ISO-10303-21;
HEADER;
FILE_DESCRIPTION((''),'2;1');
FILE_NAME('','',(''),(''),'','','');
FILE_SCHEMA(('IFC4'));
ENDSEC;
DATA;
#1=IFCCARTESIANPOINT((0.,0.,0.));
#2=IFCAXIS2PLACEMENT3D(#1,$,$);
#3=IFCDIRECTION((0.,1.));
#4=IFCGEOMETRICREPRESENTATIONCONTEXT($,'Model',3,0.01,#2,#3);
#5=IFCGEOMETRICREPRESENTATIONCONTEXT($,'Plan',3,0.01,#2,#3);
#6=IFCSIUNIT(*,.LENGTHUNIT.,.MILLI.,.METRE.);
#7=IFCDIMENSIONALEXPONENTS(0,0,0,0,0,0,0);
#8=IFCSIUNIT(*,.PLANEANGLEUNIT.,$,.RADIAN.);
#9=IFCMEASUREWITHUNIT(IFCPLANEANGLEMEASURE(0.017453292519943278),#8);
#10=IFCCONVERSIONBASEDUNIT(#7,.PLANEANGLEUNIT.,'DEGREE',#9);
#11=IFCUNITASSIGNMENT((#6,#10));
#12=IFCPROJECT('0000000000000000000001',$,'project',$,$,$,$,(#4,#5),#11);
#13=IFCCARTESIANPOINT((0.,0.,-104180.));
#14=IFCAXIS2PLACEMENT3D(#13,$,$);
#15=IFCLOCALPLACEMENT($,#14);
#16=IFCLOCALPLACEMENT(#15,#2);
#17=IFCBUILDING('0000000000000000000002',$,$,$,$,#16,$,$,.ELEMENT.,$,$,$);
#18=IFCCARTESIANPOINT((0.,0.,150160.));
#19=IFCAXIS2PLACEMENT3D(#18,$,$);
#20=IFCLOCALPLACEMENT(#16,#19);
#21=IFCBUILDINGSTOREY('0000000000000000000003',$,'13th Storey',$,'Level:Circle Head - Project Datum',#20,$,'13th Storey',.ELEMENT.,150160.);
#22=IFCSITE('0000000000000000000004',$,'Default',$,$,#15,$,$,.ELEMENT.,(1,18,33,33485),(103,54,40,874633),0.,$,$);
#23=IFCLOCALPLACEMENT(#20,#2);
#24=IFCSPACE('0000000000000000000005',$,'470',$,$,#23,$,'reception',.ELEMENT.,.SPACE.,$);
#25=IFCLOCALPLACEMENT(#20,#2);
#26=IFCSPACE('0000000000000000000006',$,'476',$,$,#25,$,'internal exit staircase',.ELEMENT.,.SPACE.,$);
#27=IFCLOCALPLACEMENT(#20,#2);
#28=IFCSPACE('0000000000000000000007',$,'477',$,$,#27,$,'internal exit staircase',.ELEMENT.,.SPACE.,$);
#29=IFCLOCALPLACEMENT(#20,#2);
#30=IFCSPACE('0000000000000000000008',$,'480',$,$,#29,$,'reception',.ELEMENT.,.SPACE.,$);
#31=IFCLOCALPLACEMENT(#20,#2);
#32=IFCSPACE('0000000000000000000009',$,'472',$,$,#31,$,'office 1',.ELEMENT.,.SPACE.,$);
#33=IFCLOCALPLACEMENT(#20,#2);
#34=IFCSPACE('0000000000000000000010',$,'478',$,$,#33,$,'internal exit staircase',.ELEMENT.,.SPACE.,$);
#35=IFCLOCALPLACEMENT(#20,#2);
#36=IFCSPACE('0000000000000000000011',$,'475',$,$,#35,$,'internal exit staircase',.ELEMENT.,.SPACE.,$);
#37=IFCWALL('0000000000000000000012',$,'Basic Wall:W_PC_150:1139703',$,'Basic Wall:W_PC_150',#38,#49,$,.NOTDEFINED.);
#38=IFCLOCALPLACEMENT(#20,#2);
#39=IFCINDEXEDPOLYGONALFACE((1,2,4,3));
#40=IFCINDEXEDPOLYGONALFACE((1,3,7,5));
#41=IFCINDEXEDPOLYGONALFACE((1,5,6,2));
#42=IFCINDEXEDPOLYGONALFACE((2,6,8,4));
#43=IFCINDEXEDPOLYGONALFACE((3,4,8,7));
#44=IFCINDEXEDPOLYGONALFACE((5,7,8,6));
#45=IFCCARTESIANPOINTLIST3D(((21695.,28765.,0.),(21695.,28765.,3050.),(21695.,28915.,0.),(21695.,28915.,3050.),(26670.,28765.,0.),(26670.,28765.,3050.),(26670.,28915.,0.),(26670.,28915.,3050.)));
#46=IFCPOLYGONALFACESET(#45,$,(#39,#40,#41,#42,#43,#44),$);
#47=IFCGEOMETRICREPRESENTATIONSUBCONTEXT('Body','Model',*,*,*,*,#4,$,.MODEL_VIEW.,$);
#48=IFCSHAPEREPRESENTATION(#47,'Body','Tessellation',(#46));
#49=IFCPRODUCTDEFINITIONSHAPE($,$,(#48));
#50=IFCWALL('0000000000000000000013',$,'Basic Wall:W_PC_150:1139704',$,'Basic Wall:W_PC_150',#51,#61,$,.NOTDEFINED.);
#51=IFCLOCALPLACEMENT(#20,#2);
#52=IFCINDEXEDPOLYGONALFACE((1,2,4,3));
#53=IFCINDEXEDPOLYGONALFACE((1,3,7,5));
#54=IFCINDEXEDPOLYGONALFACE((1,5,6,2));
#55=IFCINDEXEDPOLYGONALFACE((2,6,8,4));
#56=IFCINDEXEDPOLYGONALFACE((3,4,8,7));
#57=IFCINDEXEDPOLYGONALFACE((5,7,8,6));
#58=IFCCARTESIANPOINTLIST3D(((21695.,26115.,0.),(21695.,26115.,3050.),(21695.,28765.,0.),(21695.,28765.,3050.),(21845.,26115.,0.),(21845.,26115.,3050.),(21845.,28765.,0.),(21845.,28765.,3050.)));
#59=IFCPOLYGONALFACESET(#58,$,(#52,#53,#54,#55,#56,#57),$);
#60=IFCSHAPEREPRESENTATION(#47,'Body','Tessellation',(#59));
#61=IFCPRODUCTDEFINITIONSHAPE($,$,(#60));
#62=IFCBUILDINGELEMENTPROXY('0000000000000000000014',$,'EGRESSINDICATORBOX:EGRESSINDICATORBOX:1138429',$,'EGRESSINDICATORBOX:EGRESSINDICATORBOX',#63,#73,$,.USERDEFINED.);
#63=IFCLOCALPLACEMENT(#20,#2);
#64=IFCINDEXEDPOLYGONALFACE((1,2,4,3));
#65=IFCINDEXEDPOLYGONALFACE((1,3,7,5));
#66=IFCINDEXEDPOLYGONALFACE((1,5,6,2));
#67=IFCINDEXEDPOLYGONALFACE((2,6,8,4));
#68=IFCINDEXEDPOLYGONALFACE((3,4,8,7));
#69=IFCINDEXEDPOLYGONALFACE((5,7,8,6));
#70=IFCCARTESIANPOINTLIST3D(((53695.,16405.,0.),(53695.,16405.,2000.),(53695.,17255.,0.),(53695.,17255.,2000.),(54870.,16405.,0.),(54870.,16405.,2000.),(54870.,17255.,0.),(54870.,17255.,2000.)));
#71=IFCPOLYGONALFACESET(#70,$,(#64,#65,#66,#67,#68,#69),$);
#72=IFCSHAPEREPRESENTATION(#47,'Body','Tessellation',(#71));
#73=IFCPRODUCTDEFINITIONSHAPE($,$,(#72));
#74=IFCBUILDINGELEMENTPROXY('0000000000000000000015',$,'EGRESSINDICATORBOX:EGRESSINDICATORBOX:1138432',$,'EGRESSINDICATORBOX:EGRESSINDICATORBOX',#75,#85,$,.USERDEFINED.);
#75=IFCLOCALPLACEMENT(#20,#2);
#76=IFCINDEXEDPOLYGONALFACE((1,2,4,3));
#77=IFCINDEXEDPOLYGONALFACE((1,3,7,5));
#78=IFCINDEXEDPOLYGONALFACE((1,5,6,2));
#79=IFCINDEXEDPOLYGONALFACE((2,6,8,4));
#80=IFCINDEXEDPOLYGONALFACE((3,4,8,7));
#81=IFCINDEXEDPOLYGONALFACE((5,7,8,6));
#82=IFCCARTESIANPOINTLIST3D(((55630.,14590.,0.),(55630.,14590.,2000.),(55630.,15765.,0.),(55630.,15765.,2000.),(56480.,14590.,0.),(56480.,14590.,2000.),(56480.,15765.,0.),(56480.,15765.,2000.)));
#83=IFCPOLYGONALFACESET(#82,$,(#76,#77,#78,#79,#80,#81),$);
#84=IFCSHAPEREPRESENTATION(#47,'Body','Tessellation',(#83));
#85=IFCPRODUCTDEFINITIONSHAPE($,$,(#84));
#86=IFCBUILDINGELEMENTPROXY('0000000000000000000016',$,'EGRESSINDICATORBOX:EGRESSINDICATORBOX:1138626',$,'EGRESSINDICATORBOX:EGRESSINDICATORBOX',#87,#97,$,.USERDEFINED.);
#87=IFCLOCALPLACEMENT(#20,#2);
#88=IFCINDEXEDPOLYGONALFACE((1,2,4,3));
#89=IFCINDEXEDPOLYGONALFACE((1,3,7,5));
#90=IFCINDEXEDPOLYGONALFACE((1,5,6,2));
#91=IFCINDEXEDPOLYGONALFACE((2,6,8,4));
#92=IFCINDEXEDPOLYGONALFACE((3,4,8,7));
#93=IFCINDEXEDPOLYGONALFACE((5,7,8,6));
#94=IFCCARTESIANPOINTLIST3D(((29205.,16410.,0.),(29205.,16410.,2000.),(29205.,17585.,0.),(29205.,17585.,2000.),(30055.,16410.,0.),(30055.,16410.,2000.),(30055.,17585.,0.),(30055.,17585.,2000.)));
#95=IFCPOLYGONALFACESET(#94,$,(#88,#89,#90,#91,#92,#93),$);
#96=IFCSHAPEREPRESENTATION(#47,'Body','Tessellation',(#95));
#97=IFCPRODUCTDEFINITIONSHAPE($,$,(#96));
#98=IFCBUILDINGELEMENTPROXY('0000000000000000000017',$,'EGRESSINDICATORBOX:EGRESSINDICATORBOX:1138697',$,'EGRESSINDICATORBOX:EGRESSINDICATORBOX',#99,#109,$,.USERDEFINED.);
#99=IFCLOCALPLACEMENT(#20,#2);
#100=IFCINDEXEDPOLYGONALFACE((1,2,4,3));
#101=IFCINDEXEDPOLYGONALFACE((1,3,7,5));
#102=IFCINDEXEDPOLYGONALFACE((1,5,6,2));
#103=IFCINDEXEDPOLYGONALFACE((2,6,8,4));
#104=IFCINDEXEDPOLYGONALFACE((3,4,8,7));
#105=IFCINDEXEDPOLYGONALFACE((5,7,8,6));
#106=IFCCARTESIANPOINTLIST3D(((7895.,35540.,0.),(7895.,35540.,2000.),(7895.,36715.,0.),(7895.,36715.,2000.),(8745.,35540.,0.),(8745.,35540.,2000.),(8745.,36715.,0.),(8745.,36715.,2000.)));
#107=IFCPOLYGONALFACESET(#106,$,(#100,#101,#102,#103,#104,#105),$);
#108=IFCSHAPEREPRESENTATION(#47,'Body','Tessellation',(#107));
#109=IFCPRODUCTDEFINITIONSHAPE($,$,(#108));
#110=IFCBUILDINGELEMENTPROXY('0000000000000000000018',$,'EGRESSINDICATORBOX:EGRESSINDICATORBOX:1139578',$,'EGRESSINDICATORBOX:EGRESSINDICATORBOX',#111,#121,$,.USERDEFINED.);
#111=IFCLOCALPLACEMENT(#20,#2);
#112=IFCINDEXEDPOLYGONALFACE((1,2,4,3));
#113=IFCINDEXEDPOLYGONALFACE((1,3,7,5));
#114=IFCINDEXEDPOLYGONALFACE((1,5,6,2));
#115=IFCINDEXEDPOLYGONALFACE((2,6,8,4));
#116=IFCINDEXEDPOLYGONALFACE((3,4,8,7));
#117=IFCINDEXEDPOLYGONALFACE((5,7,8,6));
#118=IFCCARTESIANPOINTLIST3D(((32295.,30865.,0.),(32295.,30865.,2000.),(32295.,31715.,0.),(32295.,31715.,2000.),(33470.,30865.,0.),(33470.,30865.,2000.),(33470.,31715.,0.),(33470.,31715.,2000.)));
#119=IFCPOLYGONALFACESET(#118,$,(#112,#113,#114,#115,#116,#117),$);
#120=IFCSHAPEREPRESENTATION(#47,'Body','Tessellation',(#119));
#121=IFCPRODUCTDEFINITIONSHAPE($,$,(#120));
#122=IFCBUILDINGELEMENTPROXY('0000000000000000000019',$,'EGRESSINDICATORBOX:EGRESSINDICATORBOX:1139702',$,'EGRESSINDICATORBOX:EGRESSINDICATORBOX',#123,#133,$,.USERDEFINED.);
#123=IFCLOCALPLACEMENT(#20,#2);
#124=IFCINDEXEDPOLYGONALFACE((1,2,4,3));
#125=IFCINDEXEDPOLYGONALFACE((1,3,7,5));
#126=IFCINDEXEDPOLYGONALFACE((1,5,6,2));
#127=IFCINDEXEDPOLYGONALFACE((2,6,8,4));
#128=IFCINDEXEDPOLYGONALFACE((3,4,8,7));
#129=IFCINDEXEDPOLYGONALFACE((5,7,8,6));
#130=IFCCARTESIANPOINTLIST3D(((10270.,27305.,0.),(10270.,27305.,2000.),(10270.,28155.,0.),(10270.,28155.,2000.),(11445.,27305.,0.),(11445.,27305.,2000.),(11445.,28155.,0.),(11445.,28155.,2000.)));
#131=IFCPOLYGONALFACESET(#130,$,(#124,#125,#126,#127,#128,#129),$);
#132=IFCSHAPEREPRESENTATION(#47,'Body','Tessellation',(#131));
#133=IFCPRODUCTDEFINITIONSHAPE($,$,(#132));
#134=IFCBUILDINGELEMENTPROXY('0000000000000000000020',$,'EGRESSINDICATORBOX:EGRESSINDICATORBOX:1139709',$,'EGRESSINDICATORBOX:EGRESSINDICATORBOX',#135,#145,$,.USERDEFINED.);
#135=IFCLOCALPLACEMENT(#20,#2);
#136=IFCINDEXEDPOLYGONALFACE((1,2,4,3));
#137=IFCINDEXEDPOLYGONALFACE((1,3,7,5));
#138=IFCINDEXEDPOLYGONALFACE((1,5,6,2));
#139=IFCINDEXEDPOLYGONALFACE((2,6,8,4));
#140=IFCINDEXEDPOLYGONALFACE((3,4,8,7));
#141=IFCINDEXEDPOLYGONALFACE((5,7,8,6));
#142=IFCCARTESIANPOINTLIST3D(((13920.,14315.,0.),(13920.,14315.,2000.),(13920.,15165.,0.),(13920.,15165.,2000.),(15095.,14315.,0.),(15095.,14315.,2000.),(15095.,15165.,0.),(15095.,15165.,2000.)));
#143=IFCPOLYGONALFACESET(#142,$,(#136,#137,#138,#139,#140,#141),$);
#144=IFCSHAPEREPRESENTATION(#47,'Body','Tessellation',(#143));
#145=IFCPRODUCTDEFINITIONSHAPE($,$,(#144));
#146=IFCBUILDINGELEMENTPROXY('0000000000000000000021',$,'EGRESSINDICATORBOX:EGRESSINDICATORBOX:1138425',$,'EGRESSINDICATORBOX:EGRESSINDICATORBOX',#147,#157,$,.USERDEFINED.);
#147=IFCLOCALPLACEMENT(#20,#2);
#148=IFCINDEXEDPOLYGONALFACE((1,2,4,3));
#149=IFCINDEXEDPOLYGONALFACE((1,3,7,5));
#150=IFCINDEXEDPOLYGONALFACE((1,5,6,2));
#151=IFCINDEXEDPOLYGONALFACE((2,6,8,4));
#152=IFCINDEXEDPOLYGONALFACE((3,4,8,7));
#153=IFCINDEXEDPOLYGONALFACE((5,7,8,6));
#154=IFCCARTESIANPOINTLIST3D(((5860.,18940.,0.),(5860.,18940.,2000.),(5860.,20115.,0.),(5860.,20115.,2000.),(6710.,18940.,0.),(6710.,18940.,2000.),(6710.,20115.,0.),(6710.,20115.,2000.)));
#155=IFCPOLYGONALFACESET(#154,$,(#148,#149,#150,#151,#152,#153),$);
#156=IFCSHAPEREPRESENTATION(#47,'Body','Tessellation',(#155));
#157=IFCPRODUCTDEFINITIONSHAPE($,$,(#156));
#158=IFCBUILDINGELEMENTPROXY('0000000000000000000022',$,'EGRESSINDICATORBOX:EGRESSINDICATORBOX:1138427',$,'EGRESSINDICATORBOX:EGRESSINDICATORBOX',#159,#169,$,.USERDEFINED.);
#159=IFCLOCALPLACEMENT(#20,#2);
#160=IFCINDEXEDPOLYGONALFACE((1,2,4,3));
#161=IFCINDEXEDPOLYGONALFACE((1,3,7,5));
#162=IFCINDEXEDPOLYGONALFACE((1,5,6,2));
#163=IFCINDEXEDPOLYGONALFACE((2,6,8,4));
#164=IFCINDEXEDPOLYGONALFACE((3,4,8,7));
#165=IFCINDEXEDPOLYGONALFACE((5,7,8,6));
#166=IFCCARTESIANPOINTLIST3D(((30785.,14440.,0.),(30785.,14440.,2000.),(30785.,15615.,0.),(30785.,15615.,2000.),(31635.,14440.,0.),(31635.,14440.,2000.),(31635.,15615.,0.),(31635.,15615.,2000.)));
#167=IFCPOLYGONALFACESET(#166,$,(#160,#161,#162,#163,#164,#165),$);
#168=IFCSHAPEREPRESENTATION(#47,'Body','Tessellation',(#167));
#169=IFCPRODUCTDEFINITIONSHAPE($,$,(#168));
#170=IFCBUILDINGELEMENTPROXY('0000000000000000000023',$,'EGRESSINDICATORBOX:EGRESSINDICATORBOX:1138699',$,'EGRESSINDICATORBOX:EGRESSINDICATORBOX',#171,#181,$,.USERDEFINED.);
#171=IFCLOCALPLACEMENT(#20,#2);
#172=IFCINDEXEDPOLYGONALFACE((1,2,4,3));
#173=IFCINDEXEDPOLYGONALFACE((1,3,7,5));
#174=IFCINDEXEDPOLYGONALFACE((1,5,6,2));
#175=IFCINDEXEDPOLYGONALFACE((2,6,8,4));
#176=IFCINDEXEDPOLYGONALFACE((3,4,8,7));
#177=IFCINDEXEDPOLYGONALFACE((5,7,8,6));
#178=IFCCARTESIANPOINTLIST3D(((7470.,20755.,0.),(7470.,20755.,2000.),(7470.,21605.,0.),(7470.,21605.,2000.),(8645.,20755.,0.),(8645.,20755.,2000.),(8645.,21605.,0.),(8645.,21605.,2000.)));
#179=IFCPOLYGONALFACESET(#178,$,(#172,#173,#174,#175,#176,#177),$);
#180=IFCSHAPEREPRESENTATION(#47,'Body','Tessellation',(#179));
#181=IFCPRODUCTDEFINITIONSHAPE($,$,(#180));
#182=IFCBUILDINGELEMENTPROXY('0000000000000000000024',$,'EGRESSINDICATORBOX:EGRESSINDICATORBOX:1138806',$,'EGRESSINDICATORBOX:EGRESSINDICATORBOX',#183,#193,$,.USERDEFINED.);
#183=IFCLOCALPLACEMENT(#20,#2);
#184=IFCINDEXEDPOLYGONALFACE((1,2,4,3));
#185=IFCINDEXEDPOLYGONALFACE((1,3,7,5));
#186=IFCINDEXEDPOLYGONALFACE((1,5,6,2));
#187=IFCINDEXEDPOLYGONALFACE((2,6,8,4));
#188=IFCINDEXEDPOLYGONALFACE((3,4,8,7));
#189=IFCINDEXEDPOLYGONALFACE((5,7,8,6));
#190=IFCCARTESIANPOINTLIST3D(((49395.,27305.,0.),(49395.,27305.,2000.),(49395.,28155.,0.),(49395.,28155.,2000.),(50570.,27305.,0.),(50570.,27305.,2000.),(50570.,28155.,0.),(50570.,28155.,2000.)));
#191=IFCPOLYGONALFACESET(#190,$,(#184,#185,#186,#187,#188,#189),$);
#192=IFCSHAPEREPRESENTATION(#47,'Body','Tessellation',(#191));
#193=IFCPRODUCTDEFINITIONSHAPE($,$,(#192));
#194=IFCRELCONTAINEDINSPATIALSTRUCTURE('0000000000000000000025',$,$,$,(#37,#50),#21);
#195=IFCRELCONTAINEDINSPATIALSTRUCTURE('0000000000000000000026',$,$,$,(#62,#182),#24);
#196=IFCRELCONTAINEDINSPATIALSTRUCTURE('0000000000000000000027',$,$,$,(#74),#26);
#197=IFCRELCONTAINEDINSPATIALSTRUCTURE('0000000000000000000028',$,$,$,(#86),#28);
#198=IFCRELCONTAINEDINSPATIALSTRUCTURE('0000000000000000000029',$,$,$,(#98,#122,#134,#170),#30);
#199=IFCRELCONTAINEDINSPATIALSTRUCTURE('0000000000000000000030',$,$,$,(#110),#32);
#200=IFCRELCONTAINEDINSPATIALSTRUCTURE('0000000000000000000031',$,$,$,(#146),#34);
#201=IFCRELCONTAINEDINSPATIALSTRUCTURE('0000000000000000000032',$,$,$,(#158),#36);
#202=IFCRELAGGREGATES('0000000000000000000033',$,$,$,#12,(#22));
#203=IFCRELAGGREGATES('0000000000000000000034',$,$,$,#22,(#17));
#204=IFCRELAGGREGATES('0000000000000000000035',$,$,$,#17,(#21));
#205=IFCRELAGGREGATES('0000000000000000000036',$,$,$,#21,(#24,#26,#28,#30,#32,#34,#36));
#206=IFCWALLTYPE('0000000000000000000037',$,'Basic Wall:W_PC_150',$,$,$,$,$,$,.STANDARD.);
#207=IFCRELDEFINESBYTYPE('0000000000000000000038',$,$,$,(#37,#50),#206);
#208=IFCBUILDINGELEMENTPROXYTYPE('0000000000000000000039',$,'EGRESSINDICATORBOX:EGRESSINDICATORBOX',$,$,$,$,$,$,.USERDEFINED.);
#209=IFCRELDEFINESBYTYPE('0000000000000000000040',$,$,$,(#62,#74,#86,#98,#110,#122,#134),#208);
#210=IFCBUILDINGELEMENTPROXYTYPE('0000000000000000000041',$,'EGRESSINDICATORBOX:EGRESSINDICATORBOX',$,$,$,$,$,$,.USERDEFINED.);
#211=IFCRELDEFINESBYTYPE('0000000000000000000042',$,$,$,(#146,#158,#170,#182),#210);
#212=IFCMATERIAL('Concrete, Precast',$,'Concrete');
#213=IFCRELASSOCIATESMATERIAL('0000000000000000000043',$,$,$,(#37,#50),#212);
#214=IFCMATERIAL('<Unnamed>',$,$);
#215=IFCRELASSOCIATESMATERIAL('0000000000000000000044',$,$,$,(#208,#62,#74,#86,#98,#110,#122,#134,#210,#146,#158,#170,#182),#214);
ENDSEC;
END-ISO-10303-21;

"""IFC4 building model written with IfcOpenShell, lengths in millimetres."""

from ifc_helpers import new_model, entity, si_unit, converted_unit, direction, frame, origin, place, context, subcontext, project, spatial, indexed_curve, outline, extrude, source, transform, mapped, material, type_object, type_shapes, element, save


model = new_model("IFC4")

# Units and contexts
model_context = context("Model", 3, precision=0.01, world=origin(), true_north=direction((0.0, 1.0)))
plan_context = context("Plan", 3, precision=0.01, world=origin(), true_north=direction((0.0, 1.0)))
body_context = subcontext(model_context, "Body", "Model", "MODEL_VIEW")
ifc_project = project(units=[si_unit("LENGTHUNIT", "METRE", prefix="MILLI"), converted_unit("PLANEANGLEUNIT", "DEGREE", entity("IfcPlaneAngleMeasure", 0.017453292519943278), si_unit("PLANEANGLEUNIT", "RADIAN"), dimensions=[0, 0, 0, 0, 0, 0, 0])], contexts=[model_context, plan_context])

# Site, building, storey
site_placement = place(None, frame((0.0, 0.0, -104180.0)))
site = spatial("IfcSite", under=ifc_project, at=site_placement, Name="Default", CompositionType="ELEMENT", RefLatitude=(1, 18, 33, 33485), RefLongitude=(103, 54, 40, 874633), RefElevation=0.0)
building_placement = place(site_placement, origin())
building = spatial("IfcBuilding", under=site, at=building_placement, CompositionType="ELEMENT")
storey_placement = place(building_placement, frame((0.0, 0.0, 150160.0)))
storey = spatial("IfcBuildingStorey", under=building, at=storey_placement, Name="13th Storey", ObjectType="Level:Circle Head - Project Datum", LongName="13th Storey", CompositionType="ELEMENT", Elevation=150160.0)

# Shared definitions
ifc_material_1 = material(Name="Concrete, Precast", Category="Concrete")

# Walls
wall_type = type_object("IfcWallType", Name="Basic Wall:W_PC_150", PredefinedType="STANDARD")
wall_1_placement = place(storey_placement, frame((21695.0, 28840.0, 0.0)))
element("IfcWall", 1, at=wall_1_placement, inside=storey, type_object=wall_type, material=ifc_material_1, Name="Basic Wall:W_PC_150:1139703", ObjectType="Basic Wall:W_PC_150", PredefinedType="NOTDEFINED", context=body_context, shape_type="SweptSolid", body=[
    extrude(outline(indexed_curve([(4975.0, 75.0), (0.0, 75.0), (0.0, -75.0), (4975.0, -75.0), (4975.0, 75.0)], self_intersect=False)), origin(), (0.0, 0.0, 1.0), 3050.0),
])
wall_2_placement = place(storey_placement, frame((21770.0, 26115.0, 0.0), z_axis=(0.0, 0.0, 1.0), x_axis=(0.0, 1.0, 0.0)))
element("IfcWall", 2, at=wall_2_placement, inside=storey, type_object=wall_type, material=ifc_material_1, Name="Basic Wall:W_PC_150:1139704", ObjectType="Basic Wall:W_PC_150", PredefinedType="NOTDEFINED", context=body_context, shape_type="SweptSolid", body=[
    extrude(outline(indexed_curve([(2650.0, 75.0), (0.0, 75.0), (0.0, -75.0), (2650.0, -75.0), (2650.0, 75.0)], self_intersect=False)), origin(), (0.0, 0.0, 1.0), 3050.0),
])

# Shared definitions
space_1_placement = place(storey_placement, origin())
space_1 = spatial("IfcSpace", under=storey, at=space_1_placement, Name="470", LongName="reception", CompositionType="ELEMENT", PredefinedType="SPACE")

# Building element proxy
ifc_material_2 = material(Name="<Unnamed>")
building_element_proxy_type_1 = type_object("IfcBuildingElementProxyType", Name="EGRESSINDICATORBOX:EGRESSINDICATORBOX", PredefinedType="USERDEFINED", material=ifc_material_2)
shared_shape_1 = source(origin(), body_context, "Body", "SweptSolid", [
    extrude(outline(indexed_curve([(-587.5, -425.0), (587.5, -425.0), (587.5, 425.0), (-587.5, 425.0), (-587.5, -425.0)], self_intersect=False)), frame((0.0, 0.0, 0.0), z_axis=(0.0, 0.0, 1.0), x_axis=(0.0, 1.0, 0.0)), (0.0, 0.0, 1.0), 2000.0),
])
type_shapes(building_element_proxy_type_1, [shared_shape_1])
proxy_1_placement = place(space_1_placement, frame((54282.5, 16830.0, 0.0), z_axis=(0.0, 0.0, 1.0), x_axis=(0.0, -1.0, 0.0)))
element("IfcBuildingElementProxy", 3, at=proxy_1_placement, inside=space_1, type_object=building_element_proxy_type_1, material=ifc_material_2, Name="EGRESSINDICATORBOX:EGRESSINDICATORBOX:1138429", ObjectType="EGRESSINDICATORBOX:EGRESSINDICATORBOX", PredefinedType="USERDEFINED", context=body_context, shape_type="MappedRepresentation", body=[
    mapped(shared_shape_1, transform((0.0, 0.0, 0.0), scale=1.0)),
])

# Shared definitions
space_2_placement = place(storey_placement, origin())
space_2 = spatial("IfcSpace", under=storey, at=space_2_placement, Name="476", LongName="internal exit staircase", CompositionType="ELEMENT", PredefinedType="SPACE")

# Building element proxy
proxy_2_placement = place(space_2_placement, frame((56055.0, 15177.5, 0.0)))
element("IfcBuildingElementProxy", 4, at=proxy_2_placement, inside=space_2, type_object=building_element_proxy_type_1, material=ifc_material_2, Name="EGRESSINDICATORBOX:EGRESSINDICATORBOX:1138432", ObjectType="EGRESSINDICATORBOX:EGRESSINDICATORBOX", PredefinedType="USERDEFINED", context=body_context, shape_type="MappedRepresentation", body=[
    mapped(shared_shape_1, transform((0.0, 0.0, 0.0), scale=1.0)),
])

# Shared definitions
space_3_placement = place(storey_placement, origin())
space_3 = spatial("IfcSpace", under=storey, at=space_3_placement, Name="477", LongName="internal exit staircase", CompositionType="ELEMENT", PredefinedType="SPACE")

# Building element proxy
proxy_3_placement = place(space_3_placement, frame((29630.0, 16997.5, 0.0)))
element("IfcBuildingElementProxy", 5, at=proxy_3_placement, inside=space_3, type_object=building_element_proxy_type_1, material=ifc_material_2, Name="EGRESSINDICATORBOX:EGRESSINDICATORBOX:1138626", ObjectType="EGRESSINDICATORBOX:EGRESSINDICATORBOX", PredefinedType="USERDEFINED", context=body_context, shape_type="MappedRepresentation", body=[
    mapped(shared_shape_1, transform((0.0, 0.0, 0.0), scale=1.0)),
])

# Shared definitions
space_4_placement = place(storey_placement, origin())
space_4 = spatial("IfcSpace", under=storey, at=space_4_placement, Name="480", LongName="reception", CompositionType="ELEMENT", PredefinedType="SPACE")

# Building element proxy
proxy_4_placement = place(space_4_placement, frame((8320.0, 36127.5, 0.0)))
element("IfcBuildingElementProxy", 6, at=proxy_4_placement, inside=space_4, type_object=building_element_proxy_type_1, material=ifc_material_2, Name="EGRESSINDICATORBOX:EGRESSINDICATORBOX:1138697", ObjectType="EGRESSINDICATORBOX:EGRESSINDICATORBOX", PredefinedType="USERDEFINED", context=body_context, shape_type="MappedRepresentation", body=[
    mapped(shared_shape_1, transform((0.0, 0.0, 0.0), scale=1.0)),
])

# Shared definitions
space_5_placement = place(storey_placement, origin())
space_5 = spatial("IfcSpace", under=storey, at=space_5_placement, Name="472", LongName="office 1", CompositionType="ELEMENT", PredefinedType="SPACE")

# Building element proxies
proxy_5_placement = place(space_5_placement, frame((32882.5, 31290.0, 0.0), z_axis=(0.0, 0.0, 1.0), x_axis=(0.0, 1.0, 0.0)))
element("IfcBuildingElementProxy", 7, at=proxy_5_placement, inside=space_5, type_object=building_element_proxy_type_1, material=ifc_material_2, Name="EGRESSINDICATORBOX:EGRESSINDICATORBOX:1139578", ObjectType="EGRESSINDICATORBOX:EGRESSINDICATORBOX", PredefinedType="USERDEFINED", context=body_context, shape_type="MappedRepresentation", body=[
    mapped(shared_shape_1, transform((0.0, 0.0, 0.0), scale=1.0)),
])
for number, where, z_axis, x_axis, name in (
    (8, (10857.5, 27730.0, 0.0), (0.0, 0.0, 1.0), (0.0, -1.0, 0.0), "EGRESSINDICATORBOX:EGRESSINDICATORBOX:1139702"),
    (9, (14507.5, 14740.0, 0.0), (0.0, 0.0, 1.0), (0.0, -1.0, 0.0), "EGRESSINDICATORBOX:EGRESSINDICATORBOX:1139709"),
):
    element("IfcBuildingElementProxy", number, at=place(space_4_placement, frame(where, z_axis=z_axis, x_axis=x_axis)), inside=space_4, type_object=building_element_proxy_type_1, material=ifc_material_2, Name=name, ObjectType="EGRESSINDICATORBOX:EGRESSINDICATORBOX", PredefinedType="USERDEFINED", context=body_context, shape_type="MappedRepresentation", body=[
        mapped(shared_shape_1, transform((0.0, 0.0, 0.0), scale=1.0)),
    ])

# Shared definitions
space_6_placement = place(storey_placement, origin())
space_6 = spatial("IfcSpace", under=storey, at=space_6_placement, Name="478", LongName="internal exit staircase", CompositionType="ELEMENT", PredefinedType="SPACE")

# Building element proxy
building_element_proxy_type_2 = type_object("IfcBuildingElementProxyType", Name="EGRESSINDICATORBOX:EGRESSINDICATORBOX", PredefinedType="USERDEFINED", material=ifc_material_2)
shared_shape_2 = source(origin(), body_context, "Body", "SweptSolid", [
    extrude(outline(indexed_curve([(-425.0, -587.5), (425.0, -587.5), (425.0, 587.5), (-425.0, 587.5), (-425.0, -587.5)], self_intersect=False)), frame((0.0, 0.0, 0.0), z_axis=(0.0, 0.0, 1.0), x_axis=(-1.0, 0.0, 0.0)), (0.0, 0.0, 1.0), 2000.0),
])
type_shapes(building_element_proxy_type_2, [shared_shape_2])
proxy_6_placement = place(space_6_placement, frame((6285.0, 19527.5, 0.0), z_axis=(0.0, 0.0, 1.0), x_axis=(-1.0, 0.0, 0.0)))
element("IfcBuildingElementProxy", 10, at=proxy_6_placement, inside=space_6, type_object=building_element_proxy_type_2, material=ifc_material_2, Name="EGRESSINDICATORBOX:EGRESSINDICATORBOX:1138425", ObjectType="EGRESSINDICATORBOX:EGRESSINDICATORBOX", PredefinedType="USERDEFINED", context=body_context, shape_type="MappedRepresentation", body=[
    mapped(shared_shape_2, transform((0.0, 0.0, 0.0), scale=1.0)),
])

# Shared definitions
space_7_placement = place(storey_placement, origin())
space_7 = spatial("IfcSpace", under=storey, at=space_7_placement, Name="475", LongName="internal exit staircase", CompositionType="ELEMENT", PredefinedType="SPACE")

# Building element proxies
proxy_7_placement = place(space_7_placement, frame((31210.0, 15027.5, 0.0), z_axis=(0.0, 0.0, 1.0), x_axis=(-1.0, 0.0, 0.0)))
element("IfcBuildingElementProxy", 11, at=proxy_7_placement, inside=space_7, type_object=building_element_proxy_type_2, material=ifc_material_2, Name="EGRESSINDICATORBOX:EGRESSINDICATORBOX:1138427", ObjectType="EGRESSINDICATORBOX:EGRESSINDICATORBOX", PredefinedType="USERDEFINED", context=body_context, shape_type="MappedRepresentation", body=[
    mapped(shared_shape_2, transform((0.0, 0.0, 0.0), scale=1.0)),
])
proxy_8_placement = place(space_4_placement, frame((8057.5, 21180.0, 0.0), z_axis=(0.0, 0.0, 1.0), x_axis=(0.0, -1.0, 0.0)))
element("IfcBuildingElementProxy", 12, at=proxy_8_placement, inside=space_4, type_object=building_element_proxy_type_2, material=ifc_material_2, Name="EGRESSINDICATORBOX:EGRESSINDICATORBOX:1138699", ObjectType="EGRESSINDICATORBOX:EGRESSINDICATORBOX", PredefinedType="USERDEFINED", context=body_context, shape_type="MappedRepresentation", body=[
    mapped(shared_shape_2, transform((0.0, 0.0, 0.0), scale=1.0)),
])
for number, where, z_axis, x_axis, name in (
    (13, (49982.5, 27730.0, 0.0), (0.0, 0.0, 1.0), (0.0, -1.0, 0.0), "EGRESSINDICATORBOX:EGRESSINDICATORBOX:1138806"),
):
    element("IfcBuildingElementProxy", number, at=place(space_1_placement, frame(where, z_axis=z_axis, x_axis=x_axis)), inside=space_1, type_object=building_element_proxy_type_2, material=ifc_material_2, Name=name, ObjectType="EGRESSINDICATORBOX:EGRESSINDICATORBOX", PredefinedType="USERDEFINED", context=body_context, shape_type="MappedRepresentation", body=[
        mapped(shared_shape_2, transform((0.0, 0.0, 0.0), scale=1.0)),
    ])

save(model, "model.ifc")
